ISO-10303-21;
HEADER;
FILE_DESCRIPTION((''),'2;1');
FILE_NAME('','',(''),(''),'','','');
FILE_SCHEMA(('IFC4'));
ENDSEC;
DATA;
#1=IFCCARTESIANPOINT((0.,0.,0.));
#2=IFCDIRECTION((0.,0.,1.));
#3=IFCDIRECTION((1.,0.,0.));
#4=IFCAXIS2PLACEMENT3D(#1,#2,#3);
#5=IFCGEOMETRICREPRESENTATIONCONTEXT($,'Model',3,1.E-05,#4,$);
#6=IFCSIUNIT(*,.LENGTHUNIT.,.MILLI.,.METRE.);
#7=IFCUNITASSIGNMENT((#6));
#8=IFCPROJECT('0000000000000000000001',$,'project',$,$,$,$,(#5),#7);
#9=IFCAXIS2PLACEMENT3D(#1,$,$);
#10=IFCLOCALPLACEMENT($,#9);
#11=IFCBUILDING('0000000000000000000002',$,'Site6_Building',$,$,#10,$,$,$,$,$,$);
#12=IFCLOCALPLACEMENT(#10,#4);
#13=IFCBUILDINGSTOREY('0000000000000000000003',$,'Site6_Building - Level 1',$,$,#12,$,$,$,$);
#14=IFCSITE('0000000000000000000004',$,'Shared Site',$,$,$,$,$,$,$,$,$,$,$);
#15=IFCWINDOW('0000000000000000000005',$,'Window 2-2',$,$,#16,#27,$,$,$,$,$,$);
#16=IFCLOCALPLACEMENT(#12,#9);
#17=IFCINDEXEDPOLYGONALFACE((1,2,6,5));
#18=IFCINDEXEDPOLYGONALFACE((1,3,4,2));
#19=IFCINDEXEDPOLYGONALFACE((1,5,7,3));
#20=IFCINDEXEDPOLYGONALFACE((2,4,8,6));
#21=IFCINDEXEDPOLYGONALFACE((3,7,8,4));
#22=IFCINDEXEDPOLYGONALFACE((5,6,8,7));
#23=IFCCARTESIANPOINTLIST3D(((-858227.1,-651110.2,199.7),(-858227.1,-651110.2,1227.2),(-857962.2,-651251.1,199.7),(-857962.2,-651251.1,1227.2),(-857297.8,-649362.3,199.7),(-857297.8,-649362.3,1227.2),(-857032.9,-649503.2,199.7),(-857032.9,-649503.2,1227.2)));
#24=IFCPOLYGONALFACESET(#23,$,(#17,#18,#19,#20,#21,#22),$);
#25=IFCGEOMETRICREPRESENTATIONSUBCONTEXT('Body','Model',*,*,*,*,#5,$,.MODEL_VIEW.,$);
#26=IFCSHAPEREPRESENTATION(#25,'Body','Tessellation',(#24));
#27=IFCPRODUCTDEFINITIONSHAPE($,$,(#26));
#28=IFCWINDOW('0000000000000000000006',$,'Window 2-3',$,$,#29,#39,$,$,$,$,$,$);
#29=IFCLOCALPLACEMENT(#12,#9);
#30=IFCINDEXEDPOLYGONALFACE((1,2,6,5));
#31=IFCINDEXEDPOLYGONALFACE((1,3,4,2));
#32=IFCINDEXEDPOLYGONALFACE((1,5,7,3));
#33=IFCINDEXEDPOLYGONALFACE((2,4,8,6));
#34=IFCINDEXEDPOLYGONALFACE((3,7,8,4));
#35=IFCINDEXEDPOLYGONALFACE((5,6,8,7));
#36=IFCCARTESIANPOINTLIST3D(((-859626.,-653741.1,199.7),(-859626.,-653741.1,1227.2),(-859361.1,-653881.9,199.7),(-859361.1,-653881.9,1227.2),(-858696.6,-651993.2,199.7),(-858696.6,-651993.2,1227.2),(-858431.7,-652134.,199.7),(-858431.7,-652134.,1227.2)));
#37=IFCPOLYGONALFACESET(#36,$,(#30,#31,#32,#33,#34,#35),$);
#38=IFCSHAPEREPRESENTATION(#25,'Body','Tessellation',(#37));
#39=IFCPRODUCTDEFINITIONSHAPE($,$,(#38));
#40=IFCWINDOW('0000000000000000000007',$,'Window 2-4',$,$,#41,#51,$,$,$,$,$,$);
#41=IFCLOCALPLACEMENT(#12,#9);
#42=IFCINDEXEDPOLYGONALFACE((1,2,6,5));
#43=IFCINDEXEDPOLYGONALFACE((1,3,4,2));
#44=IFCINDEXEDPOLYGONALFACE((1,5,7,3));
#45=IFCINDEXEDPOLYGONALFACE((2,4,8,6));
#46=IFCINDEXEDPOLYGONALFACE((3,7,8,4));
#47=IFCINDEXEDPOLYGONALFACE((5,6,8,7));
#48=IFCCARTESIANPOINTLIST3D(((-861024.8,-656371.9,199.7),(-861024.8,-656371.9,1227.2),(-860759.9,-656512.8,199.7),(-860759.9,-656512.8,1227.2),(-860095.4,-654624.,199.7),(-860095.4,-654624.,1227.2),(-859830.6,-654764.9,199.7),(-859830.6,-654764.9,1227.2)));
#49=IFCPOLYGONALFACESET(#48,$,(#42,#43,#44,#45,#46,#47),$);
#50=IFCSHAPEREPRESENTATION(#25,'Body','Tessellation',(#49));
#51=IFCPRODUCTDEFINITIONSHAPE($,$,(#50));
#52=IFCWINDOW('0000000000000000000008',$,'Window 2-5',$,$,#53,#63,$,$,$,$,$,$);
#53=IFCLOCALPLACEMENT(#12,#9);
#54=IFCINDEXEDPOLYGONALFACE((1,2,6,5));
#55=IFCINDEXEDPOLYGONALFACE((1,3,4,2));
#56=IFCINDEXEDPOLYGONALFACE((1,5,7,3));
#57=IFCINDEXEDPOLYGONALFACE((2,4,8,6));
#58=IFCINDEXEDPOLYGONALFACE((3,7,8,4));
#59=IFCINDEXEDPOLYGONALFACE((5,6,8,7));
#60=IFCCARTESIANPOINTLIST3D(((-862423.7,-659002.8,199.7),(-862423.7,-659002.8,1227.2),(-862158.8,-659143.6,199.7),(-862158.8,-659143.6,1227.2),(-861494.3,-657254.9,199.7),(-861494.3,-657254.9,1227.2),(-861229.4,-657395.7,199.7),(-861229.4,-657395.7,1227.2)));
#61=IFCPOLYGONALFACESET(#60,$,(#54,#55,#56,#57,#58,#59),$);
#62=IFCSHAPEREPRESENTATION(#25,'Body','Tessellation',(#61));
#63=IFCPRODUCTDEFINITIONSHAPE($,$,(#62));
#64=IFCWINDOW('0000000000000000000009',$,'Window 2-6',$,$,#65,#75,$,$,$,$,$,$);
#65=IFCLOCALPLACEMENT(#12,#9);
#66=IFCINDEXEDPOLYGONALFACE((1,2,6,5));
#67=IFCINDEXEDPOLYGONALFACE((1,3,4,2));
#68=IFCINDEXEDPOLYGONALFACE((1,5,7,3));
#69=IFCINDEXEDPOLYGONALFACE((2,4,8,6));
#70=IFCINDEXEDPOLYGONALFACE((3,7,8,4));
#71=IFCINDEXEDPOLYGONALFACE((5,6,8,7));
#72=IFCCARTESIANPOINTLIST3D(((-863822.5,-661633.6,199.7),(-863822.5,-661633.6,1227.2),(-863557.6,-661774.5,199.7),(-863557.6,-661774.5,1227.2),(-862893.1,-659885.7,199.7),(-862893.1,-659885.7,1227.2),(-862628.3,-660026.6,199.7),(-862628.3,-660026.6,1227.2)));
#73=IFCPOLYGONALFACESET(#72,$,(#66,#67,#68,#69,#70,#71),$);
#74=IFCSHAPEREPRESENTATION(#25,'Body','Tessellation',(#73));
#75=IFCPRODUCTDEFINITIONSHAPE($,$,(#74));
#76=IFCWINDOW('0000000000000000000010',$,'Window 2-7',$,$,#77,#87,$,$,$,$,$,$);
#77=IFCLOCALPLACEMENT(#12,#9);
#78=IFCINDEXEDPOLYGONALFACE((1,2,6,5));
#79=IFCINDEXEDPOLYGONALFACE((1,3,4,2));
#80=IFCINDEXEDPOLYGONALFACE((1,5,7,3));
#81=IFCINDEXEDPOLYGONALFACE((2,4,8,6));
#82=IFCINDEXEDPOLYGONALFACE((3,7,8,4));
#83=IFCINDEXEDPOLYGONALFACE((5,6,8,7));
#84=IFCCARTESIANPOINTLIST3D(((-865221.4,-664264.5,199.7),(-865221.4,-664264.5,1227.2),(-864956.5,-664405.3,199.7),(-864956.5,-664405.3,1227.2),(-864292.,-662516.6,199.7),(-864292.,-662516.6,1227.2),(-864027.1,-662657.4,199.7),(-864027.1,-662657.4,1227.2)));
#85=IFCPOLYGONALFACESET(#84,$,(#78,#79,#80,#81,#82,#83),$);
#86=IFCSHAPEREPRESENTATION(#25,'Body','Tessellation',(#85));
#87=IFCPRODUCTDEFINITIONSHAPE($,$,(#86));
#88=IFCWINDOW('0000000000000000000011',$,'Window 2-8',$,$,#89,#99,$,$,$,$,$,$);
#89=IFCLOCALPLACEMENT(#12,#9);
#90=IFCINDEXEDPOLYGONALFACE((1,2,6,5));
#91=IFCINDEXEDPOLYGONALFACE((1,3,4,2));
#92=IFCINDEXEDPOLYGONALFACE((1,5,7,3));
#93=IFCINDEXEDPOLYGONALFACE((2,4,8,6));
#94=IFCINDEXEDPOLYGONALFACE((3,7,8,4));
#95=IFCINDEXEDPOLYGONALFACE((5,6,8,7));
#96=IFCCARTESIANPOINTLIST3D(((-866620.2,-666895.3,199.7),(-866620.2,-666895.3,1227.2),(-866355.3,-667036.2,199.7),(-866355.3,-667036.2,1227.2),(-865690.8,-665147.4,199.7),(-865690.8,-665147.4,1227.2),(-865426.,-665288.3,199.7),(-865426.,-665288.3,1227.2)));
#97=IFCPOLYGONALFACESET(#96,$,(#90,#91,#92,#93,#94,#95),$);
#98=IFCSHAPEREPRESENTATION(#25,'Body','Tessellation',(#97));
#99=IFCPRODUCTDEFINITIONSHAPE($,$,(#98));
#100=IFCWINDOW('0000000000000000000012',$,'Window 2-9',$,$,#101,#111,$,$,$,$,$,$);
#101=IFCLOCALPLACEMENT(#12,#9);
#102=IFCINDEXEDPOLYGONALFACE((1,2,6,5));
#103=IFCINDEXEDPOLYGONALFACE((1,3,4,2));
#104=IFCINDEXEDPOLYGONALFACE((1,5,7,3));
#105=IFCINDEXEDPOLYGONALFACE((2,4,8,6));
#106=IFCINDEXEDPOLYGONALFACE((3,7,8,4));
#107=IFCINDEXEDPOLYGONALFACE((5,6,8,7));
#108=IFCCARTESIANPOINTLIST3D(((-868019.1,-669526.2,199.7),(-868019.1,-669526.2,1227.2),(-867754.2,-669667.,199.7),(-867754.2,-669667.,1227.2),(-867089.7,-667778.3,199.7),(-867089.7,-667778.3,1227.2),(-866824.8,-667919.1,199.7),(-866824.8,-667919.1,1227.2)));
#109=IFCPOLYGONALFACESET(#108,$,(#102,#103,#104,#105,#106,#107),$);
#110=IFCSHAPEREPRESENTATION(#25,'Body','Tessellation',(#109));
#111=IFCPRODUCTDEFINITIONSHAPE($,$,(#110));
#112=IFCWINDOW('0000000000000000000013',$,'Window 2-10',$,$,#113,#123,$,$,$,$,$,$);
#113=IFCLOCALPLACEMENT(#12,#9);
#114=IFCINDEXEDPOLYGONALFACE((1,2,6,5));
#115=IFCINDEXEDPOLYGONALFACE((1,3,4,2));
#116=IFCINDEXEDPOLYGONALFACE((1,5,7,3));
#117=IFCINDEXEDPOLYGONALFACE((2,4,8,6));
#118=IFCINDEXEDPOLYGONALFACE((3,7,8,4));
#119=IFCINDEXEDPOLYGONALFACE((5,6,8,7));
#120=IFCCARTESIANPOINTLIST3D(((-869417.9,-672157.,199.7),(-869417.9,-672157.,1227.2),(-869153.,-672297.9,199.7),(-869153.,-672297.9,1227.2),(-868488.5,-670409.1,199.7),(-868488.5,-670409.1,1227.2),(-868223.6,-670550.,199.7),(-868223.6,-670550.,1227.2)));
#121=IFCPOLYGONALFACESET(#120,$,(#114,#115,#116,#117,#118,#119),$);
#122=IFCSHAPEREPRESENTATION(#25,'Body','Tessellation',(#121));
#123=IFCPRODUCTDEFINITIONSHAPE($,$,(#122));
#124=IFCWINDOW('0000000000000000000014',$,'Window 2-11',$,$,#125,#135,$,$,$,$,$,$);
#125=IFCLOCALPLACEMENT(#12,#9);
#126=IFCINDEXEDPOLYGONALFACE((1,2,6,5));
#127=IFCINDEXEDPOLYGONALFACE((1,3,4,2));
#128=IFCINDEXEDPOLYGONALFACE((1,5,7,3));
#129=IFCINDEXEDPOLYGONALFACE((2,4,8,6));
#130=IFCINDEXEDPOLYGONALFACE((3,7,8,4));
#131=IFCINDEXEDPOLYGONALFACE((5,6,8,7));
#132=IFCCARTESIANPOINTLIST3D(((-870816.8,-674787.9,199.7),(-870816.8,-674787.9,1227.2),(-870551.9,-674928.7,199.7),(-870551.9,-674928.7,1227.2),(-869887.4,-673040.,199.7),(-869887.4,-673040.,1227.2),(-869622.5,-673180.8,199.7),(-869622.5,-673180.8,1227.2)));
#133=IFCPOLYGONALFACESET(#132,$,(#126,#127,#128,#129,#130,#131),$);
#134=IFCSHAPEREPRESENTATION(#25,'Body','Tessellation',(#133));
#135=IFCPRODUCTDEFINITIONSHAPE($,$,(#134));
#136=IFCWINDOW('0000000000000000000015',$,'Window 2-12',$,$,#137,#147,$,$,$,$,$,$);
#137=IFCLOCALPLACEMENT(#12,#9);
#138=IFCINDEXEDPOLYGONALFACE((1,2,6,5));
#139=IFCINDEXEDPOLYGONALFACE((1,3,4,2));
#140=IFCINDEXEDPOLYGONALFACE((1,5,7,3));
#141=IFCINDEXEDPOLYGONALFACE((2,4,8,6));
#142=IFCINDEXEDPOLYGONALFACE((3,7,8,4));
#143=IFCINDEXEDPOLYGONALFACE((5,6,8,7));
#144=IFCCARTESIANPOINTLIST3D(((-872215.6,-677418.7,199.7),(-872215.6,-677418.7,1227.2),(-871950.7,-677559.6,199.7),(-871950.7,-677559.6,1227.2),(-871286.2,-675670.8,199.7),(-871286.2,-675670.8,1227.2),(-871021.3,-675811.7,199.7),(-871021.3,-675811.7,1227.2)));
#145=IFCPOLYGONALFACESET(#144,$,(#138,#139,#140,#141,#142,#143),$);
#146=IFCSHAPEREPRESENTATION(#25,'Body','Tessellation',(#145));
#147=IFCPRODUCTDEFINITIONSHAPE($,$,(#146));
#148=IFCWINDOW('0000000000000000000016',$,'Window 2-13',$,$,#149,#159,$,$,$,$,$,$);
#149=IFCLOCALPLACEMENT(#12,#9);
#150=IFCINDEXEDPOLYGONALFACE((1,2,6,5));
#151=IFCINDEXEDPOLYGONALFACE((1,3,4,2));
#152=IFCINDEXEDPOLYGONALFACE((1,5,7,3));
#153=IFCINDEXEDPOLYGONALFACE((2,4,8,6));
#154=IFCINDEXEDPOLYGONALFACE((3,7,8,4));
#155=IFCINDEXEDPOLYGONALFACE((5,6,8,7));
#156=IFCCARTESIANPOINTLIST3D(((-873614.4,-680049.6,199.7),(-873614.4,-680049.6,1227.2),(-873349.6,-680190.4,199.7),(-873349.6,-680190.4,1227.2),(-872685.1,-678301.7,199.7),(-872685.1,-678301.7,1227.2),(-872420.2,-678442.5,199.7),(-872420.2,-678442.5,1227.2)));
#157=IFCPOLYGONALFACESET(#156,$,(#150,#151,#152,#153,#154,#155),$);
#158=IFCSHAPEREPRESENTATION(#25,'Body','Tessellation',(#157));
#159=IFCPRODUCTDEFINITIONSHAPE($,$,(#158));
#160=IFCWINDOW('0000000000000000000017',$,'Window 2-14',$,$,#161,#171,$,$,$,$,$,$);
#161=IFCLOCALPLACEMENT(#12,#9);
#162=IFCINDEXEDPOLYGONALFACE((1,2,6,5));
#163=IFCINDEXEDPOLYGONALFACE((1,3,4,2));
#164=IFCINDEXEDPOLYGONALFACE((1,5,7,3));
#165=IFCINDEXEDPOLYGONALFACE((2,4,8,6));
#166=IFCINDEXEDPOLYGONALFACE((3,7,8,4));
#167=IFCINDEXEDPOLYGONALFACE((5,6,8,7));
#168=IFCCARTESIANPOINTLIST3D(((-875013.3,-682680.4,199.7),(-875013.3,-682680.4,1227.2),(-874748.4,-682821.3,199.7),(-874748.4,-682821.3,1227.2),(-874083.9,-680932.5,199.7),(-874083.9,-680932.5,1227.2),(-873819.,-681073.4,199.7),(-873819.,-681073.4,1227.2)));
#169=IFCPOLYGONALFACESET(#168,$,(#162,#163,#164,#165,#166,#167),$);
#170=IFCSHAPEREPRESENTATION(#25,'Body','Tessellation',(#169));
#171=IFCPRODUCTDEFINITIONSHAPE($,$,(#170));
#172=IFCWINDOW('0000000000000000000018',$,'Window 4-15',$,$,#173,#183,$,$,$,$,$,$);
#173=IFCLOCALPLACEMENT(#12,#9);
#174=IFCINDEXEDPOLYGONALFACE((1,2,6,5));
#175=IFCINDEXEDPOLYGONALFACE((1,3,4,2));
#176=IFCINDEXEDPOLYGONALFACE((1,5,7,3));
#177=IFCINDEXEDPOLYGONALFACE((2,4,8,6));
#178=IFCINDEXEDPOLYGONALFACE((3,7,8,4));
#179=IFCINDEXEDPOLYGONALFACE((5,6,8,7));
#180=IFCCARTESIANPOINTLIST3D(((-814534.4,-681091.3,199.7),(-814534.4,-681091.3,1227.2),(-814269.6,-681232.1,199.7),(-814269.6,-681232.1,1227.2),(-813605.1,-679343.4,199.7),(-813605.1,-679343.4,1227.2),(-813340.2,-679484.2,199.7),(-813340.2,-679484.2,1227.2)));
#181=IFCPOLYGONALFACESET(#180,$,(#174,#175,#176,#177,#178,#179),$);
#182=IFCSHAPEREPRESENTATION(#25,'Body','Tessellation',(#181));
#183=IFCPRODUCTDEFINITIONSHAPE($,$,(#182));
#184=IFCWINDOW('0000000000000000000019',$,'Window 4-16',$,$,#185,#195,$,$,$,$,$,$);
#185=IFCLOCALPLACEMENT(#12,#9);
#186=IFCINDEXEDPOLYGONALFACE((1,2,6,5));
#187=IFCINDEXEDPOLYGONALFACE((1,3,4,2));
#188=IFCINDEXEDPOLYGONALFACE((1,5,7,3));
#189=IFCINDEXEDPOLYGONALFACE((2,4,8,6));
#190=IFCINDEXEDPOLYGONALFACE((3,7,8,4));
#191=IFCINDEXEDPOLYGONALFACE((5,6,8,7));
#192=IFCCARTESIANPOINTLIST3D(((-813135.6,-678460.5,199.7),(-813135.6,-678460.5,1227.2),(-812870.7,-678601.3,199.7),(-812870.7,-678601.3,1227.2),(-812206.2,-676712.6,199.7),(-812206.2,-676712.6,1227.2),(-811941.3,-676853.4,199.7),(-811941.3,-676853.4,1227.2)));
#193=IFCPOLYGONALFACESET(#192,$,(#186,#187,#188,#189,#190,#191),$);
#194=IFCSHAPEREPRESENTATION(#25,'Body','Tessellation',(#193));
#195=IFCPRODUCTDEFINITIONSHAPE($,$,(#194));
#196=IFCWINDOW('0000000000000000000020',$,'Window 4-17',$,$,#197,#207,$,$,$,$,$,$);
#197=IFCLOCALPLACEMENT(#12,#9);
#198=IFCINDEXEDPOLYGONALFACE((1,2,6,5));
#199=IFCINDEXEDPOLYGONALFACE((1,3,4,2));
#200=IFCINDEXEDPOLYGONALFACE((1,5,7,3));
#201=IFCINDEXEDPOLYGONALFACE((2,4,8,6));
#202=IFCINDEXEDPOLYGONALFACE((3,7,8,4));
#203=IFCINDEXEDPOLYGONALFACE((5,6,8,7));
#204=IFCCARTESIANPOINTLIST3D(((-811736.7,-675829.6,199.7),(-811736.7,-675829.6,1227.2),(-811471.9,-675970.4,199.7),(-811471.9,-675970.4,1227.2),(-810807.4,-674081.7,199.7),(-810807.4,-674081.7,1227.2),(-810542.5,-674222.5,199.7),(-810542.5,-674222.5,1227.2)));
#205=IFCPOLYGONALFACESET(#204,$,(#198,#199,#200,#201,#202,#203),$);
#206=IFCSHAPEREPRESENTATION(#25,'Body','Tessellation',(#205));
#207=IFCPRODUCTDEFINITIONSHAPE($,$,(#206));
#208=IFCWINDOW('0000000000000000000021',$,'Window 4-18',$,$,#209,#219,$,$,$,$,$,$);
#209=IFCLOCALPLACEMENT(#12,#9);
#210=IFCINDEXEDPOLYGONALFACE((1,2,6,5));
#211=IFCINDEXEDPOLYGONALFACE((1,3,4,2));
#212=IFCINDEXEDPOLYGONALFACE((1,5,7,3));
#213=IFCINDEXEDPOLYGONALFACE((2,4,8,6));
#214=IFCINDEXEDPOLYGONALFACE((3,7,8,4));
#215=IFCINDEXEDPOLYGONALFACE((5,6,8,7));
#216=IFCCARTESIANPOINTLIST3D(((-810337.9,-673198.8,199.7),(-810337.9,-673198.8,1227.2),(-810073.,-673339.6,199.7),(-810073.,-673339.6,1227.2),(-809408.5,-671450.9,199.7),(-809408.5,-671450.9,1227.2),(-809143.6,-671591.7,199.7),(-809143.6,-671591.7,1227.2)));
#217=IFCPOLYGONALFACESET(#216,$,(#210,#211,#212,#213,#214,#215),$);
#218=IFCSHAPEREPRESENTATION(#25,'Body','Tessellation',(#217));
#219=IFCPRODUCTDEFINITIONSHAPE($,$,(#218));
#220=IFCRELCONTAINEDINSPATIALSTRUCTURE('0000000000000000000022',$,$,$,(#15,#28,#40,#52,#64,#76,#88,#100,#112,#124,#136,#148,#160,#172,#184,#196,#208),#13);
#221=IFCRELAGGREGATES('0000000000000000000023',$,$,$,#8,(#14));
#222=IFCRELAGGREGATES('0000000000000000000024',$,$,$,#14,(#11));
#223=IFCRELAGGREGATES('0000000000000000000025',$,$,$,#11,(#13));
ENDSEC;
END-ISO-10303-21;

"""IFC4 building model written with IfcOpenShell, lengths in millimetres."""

from ifc_helpers import new_model, si_unit, frame, origin, origin_with_axes, place, context, subcontext, project, spatial, indexed_curve, outline, extrude, element, save


model = new_model("IFC4")

# Units and contexts
model_context = context("Model", 3, precision=1e-05, world=origin_with_axes())
body_context = subcontext(model_context, "Body", "Model", "MODEL_VIEW")
ifc_project = project(units=[si_unit("LENGTHUNIT", "METRE", prefix="MILLI")], contexts=[model_context])

# Site, building, storey
site = spatial("IfcSite", under=ifc_project, Name="Shared Site")
building_placement = place(None, origin())
building = spatial("IfcBuilding", under=site, at=building_placement, Name="Site6_Building")
storey_placement = place(building_placement, origin_with_axes())
storey = spatial("IfcBuildingStorey", under=building, at=storey_placement, Name="Site6_Building - Level 1")

# Windows
for number, where, z_axis, x_axis, name in (
    (1, (-857297.8, -649362.3, 199.7), (0.0, 0.0, 1.0), (-0.469472, -0.882948, 0.0), "Window 2-2"),
    (2, (-858696.6, -651993.2, 199.7), (0.0, 0.0, 1.0), (-0.469472, -0.882948, 0.0), "Window 2-3"),
    (3, (-860095.4, -654624.0, 199.7), (0.0, 0.0, 1.0), (-0.469472, -0.882948, 0.0), "Window 2-4"),
    (4, (-861494.3, -657254.9, 199.7), (0.0, 0.0, 1.0), (-0.469472, -0.882948, 0.0), "Window 2-5"),
    (5, (-862893.1, -659885.7, 199.7), (0.0, 0.0, 1.0), (-0.469472, -0.882948, 0.0), "Window 2-6"),
    (6, (-864292.0, -662516.6, 199.7), (0.0, 0.0, 1.0), (-0.469472, -0.882948, 0.0), "Window 2-7"),
    (7, (-865690.8, -665147.4, 199.7), (0.0, 0.0, 1.0), (-0.469472, -0.882948, 0.0), "Window 2-8"),
    (8, (-867089.7, -667778.3, 199.7), (0.0, 0.0, 1.0), (-0.469472, -0.882948, 0.0), "Window 2-9"),
    (9, (-868488.5, -670409.1, 199.7), (0.0, 0.0, 1.0), (-0.469472, -0.882948, 0.0), "Window 2-10"),
    (10, (-869887.4, -673040.0, 199.7), (0.0, 0.0, 1.0), (-0.469472, -0.882948, 0.0), "Window 2-11"),
    (11, (-871286.2, -675670.8, 199.7), (0.0, 0.0, 1.0), (-0.469472, -0.882948, 0.0), "Window 2-12"),
    (12, (-872685.1, -678301.7, 199.7), (0.0, 0.0, 1.0), (-0.469472, -0.882948, 0.0), "Window 2-13"),
    (13, (-874083.9, -680932.5, 199.7), (0.0, 0.0, 1.0), (-0.469472, -0.882948, 0.0), "Window 2-14"),
    (14, (-814269.6, -681232.1, 199.7), (0.0, 0.0, 1.0), (0.469472, 0.882948, 0.0), "Window 4-15"),
    (15, (-812870.7, -678601.3, 199.7), (0.0, 0.0, 1.0), (0.469472, 0.882948, 0.0), "Window 4-16"),
    (16, (-811471.9, -675970.4, 199.7), (0.0, 0.0, 1.0), (0.469472, 0.882948, 0.0), "Window 4-17"),
    (17, (-810073.0, -673339.6, 199.7), (0.0, 0.0, 1.0), (0.469472, 0.882948, 0.0), "Window 4-18"),
):
    element("IfcWindow", number, at=place(storey_placement, frame(where, z_axis=z_axis, x_axis=x_axis)), inside=storey, Name=name, context=body_context, shape_type="SweptSolid", body=[
        extrude(outline(indexed_curve([(0.0, 0.0), (0.0, 300.0), (1979.6, 300.0), (1979.6, 0.0), (0.0, 0.0)], self_intersect=False)), origin_with_axes(), (0.0, 0.0, 1.0), 1027.5),
    ])

save(model, "model.ifc")
